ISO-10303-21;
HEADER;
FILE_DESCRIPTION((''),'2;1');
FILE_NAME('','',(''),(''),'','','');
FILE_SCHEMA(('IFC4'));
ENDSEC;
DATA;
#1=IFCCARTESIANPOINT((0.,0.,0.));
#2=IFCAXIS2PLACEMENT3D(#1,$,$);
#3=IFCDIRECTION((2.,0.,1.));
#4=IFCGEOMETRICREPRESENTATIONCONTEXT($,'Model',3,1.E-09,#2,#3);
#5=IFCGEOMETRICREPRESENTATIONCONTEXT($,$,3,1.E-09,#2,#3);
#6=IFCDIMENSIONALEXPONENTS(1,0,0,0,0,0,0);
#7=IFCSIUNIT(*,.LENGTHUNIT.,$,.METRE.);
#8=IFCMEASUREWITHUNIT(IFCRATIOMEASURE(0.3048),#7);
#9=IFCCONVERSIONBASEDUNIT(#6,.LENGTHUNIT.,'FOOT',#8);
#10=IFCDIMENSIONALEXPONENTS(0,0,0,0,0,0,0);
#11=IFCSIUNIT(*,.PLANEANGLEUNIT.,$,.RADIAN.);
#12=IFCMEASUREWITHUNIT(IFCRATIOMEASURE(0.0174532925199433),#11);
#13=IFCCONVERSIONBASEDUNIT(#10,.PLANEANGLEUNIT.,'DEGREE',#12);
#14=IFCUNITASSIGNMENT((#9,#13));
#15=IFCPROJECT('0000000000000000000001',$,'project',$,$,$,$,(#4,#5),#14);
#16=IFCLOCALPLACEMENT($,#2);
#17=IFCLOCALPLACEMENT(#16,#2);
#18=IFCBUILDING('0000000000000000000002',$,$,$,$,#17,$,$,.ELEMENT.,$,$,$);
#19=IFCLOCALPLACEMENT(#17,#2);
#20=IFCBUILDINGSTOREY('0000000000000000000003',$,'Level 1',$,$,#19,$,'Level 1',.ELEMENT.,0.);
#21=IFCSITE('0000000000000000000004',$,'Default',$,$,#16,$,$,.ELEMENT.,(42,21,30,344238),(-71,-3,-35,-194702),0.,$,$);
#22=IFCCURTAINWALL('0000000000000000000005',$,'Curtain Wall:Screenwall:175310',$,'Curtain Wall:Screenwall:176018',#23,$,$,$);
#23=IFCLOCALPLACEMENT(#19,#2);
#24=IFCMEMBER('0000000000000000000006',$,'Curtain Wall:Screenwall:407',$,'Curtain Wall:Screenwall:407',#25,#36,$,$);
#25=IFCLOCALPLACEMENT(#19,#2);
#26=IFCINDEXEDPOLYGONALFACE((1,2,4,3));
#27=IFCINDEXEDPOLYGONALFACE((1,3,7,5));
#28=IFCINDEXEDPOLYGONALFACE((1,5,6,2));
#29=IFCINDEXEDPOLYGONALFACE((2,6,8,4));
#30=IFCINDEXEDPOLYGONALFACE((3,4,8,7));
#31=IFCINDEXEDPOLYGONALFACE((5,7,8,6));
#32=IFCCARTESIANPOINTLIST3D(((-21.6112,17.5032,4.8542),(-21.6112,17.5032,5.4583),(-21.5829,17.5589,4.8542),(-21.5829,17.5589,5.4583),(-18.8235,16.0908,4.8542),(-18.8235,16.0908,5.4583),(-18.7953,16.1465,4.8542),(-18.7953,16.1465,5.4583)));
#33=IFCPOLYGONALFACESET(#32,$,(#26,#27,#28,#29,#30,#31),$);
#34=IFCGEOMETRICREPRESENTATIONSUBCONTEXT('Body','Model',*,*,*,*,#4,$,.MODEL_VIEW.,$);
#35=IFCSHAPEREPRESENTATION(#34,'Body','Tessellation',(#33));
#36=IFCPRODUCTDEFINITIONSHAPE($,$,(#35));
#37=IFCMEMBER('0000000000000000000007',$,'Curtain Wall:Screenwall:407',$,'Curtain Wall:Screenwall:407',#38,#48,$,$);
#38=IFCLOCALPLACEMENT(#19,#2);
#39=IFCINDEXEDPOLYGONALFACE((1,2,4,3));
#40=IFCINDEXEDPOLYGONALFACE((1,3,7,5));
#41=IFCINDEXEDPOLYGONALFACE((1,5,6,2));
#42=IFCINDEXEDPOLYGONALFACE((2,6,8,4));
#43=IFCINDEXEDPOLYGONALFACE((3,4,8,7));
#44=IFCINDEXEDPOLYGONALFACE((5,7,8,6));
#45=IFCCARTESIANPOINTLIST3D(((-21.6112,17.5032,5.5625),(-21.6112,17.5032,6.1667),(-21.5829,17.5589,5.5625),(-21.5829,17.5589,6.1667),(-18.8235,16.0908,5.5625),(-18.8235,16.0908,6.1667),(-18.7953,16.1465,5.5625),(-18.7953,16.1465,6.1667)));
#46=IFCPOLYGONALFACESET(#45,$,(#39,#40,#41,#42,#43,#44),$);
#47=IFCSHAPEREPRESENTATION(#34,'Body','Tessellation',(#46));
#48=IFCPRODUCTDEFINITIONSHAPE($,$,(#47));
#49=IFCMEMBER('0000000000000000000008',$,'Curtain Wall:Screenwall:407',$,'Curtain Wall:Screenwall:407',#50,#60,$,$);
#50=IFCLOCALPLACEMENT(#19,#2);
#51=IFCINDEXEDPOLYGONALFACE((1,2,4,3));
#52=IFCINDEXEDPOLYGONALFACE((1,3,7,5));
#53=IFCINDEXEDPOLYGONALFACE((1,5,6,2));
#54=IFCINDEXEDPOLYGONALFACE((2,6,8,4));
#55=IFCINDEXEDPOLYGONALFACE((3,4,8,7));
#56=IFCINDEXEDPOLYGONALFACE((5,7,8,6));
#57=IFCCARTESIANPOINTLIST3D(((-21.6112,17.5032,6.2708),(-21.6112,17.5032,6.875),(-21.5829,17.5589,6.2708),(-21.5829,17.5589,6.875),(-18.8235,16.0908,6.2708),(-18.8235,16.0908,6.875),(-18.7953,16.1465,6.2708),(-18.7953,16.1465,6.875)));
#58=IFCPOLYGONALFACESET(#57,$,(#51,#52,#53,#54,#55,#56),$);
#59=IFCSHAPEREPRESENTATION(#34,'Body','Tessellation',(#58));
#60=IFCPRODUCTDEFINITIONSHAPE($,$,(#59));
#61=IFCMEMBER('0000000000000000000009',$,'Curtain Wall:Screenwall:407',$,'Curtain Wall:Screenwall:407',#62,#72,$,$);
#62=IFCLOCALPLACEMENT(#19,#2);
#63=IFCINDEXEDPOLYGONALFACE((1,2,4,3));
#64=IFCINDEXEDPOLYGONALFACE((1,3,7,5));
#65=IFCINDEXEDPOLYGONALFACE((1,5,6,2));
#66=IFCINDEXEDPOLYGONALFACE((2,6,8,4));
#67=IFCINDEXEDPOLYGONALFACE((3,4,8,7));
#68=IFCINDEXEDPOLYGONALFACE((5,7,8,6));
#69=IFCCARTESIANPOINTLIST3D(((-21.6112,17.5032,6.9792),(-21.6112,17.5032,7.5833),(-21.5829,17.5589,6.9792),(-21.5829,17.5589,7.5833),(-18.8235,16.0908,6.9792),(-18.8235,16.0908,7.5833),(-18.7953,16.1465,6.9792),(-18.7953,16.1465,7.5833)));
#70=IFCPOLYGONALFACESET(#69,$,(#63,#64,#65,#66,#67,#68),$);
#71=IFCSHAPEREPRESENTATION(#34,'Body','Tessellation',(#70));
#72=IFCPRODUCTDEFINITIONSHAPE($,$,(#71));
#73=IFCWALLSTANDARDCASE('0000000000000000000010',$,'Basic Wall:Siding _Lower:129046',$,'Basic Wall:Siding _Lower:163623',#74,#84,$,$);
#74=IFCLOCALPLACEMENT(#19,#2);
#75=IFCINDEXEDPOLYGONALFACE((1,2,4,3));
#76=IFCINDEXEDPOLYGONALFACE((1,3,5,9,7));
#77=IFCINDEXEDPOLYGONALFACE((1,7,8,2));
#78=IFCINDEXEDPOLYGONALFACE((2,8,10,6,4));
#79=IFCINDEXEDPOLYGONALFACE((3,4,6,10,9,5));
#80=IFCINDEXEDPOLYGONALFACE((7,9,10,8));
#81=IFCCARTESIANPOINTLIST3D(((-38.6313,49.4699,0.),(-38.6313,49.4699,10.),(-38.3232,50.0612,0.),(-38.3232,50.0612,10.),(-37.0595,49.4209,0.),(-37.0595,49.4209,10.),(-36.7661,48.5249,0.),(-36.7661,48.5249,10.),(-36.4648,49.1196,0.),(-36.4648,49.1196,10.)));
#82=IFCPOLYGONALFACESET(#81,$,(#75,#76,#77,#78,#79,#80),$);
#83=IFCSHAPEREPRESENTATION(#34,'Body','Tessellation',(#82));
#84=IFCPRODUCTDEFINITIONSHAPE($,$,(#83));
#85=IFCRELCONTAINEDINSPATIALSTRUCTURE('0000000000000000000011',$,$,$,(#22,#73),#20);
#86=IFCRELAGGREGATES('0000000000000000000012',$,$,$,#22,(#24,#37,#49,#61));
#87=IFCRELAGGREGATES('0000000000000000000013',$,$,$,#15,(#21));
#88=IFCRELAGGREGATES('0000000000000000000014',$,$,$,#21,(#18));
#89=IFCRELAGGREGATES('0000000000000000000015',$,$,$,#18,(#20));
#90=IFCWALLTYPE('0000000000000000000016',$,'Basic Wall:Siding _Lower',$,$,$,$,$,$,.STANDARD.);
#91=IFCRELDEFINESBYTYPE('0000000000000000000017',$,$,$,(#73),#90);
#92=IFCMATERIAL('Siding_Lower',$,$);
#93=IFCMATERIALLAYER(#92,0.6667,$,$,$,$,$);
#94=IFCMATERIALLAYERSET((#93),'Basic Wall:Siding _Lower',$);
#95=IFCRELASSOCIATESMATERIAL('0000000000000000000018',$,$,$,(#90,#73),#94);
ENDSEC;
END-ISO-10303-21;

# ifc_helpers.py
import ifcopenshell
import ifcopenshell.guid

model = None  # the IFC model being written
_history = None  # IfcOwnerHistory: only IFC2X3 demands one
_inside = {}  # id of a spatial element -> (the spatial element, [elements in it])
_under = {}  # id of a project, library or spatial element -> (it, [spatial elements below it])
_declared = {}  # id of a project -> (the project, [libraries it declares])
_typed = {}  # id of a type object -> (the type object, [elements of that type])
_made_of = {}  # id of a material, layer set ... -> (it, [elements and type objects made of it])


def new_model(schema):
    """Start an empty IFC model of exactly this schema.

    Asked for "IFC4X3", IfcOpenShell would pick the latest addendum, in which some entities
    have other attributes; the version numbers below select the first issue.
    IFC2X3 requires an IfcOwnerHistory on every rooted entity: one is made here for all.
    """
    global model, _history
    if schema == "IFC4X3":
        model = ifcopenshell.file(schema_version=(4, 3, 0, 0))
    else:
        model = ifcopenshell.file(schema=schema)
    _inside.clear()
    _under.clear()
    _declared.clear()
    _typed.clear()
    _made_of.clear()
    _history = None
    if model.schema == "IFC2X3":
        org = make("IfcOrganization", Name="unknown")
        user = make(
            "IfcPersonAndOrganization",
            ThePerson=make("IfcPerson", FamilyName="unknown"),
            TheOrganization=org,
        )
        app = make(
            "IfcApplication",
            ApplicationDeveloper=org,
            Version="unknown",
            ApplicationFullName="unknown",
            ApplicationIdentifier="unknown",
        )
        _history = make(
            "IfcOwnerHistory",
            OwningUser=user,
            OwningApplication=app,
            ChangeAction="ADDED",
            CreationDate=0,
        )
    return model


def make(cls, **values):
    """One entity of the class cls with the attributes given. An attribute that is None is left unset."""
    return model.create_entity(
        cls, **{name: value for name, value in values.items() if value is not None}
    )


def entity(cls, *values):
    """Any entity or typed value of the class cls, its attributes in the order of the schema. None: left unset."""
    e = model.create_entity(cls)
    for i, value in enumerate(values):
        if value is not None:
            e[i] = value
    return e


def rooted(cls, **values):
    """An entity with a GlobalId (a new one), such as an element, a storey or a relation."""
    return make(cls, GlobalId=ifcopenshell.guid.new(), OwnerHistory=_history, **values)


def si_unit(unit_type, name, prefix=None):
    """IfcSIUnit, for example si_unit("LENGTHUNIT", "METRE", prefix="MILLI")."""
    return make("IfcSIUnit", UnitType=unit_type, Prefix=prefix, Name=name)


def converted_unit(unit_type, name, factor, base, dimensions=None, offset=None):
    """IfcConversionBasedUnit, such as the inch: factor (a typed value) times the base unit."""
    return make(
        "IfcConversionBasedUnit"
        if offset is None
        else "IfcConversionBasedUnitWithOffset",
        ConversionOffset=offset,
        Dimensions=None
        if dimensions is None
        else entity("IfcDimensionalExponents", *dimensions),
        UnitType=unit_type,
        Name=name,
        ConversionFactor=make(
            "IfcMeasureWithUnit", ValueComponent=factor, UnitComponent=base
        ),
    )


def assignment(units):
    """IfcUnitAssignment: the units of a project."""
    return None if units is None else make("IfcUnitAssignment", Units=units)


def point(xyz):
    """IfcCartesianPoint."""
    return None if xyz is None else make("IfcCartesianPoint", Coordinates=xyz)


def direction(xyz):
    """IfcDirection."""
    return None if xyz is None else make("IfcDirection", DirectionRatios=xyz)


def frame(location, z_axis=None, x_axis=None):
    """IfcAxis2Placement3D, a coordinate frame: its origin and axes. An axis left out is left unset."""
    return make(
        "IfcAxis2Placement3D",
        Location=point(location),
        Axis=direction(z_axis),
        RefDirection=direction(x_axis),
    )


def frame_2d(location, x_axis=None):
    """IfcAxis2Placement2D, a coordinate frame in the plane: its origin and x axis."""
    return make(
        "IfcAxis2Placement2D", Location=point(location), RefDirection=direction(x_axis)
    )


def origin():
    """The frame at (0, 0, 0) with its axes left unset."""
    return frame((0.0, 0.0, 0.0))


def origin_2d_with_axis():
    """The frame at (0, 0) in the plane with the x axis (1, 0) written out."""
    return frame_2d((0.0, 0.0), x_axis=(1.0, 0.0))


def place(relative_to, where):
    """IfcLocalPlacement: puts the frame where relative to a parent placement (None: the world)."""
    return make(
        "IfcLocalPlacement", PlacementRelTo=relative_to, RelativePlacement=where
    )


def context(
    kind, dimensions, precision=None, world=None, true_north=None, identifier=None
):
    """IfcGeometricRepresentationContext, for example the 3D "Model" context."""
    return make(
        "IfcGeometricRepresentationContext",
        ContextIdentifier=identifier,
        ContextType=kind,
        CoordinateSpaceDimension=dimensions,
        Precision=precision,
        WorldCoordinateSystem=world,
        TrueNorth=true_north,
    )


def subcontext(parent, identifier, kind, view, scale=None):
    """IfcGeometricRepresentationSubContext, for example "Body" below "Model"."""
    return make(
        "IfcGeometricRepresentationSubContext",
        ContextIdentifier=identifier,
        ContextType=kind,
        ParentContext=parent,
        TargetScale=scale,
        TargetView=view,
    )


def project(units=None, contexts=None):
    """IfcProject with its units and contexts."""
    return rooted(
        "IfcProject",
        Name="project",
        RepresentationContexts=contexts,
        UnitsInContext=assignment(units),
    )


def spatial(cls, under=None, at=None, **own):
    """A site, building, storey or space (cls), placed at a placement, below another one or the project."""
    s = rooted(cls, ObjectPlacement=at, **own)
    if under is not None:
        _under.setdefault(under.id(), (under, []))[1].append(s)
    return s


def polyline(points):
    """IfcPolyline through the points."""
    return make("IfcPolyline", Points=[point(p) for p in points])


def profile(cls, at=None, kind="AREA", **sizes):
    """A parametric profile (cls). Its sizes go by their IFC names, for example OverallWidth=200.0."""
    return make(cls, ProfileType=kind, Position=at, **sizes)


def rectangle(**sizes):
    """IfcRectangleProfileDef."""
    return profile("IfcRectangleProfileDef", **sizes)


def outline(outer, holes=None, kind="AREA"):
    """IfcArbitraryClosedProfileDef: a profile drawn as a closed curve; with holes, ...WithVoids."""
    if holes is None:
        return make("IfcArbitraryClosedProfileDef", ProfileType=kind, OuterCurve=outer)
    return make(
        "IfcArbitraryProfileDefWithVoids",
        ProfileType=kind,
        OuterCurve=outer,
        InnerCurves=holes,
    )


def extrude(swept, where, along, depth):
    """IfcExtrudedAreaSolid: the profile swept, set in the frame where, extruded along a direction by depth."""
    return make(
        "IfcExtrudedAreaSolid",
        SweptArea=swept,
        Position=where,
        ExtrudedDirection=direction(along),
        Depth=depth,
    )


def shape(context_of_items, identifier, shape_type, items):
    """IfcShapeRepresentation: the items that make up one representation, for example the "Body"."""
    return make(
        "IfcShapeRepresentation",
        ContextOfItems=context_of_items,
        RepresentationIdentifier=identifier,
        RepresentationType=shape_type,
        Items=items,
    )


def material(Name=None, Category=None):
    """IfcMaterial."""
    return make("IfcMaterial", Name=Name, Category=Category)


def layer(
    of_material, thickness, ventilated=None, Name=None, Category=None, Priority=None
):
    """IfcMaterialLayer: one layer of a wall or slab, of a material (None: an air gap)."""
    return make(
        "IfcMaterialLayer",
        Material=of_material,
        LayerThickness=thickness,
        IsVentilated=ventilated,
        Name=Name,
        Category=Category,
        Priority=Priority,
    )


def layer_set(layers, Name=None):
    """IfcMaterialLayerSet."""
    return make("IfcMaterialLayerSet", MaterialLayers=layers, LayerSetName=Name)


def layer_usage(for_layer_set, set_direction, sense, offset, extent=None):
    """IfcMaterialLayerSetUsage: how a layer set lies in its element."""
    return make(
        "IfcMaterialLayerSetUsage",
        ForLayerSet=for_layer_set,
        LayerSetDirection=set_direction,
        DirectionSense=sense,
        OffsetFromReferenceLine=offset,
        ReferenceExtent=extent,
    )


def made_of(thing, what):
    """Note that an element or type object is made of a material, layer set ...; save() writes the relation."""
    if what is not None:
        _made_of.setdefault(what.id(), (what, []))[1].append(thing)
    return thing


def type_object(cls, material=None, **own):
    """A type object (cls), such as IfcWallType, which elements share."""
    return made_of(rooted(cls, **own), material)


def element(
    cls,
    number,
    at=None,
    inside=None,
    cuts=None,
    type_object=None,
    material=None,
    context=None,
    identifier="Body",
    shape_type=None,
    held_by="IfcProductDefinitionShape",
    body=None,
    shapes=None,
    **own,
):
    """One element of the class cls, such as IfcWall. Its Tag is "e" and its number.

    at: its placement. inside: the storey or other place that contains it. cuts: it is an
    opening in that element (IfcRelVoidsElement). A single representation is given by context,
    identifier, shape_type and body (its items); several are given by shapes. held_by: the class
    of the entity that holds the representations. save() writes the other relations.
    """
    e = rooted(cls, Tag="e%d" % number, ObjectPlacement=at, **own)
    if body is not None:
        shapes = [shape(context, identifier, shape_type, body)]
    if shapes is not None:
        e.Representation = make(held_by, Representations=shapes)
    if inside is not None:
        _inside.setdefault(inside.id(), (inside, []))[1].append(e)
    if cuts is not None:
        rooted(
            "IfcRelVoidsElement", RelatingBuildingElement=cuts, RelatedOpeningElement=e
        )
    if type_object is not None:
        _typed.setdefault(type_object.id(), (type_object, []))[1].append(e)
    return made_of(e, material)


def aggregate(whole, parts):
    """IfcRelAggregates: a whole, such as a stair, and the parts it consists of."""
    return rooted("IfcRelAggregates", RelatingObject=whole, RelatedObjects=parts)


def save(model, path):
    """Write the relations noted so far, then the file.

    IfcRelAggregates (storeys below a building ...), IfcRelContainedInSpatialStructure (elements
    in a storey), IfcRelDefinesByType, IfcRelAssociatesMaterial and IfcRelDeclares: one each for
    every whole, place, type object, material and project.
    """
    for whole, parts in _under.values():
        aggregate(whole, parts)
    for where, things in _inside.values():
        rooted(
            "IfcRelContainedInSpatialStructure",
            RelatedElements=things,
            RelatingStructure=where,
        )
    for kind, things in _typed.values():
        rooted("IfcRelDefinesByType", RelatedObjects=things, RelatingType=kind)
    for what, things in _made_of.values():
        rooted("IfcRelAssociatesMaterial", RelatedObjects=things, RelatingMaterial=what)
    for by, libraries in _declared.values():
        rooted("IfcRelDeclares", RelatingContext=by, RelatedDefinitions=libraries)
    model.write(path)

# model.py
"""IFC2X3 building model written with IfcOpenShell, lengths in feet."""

from ifc_helpers import new_model, entity, si_unit, converted_unit, direction, frame, origin, origin_2d_with_axis, place, context, subcontext, project, spatial, polyline, rectangle, outline, extrude, material, layer, layer_set, layer_usage, type_object, element, aggregate, save


model = new_model("IFC2X3")

# Units and contexts
model_context = context("Model", 3, precision=1e-09, world=origin(), true_north=direction((2.0, 0.0, 1.0)))
context_of_model = context(None, 3, precision=1e-09, world=origin(), true_north=direction((2.0, 0.0, 1.0)))
body_context = subcontext(model_context, "Body", "Model", "MODEL_VIEW")
ifc_project = project(units=[converted_unit("LENGTHUNIT", "FOOT", entity("IfcRatioMeasure", 0.3048), si_unit("LENGTHUNIT", "METRE"), dimensions=[1, 0, 0, 0, 0, 0, 0]), converted_unit("PLANEANGLEUNIT", "DEGREE", entity("IfcRatioMeasure", 0.0174532925199433), si_unit("PLANEANGLEUNIT", "RADIAN"), dimensions=[0, 0, 0, 0, 0, 0, 0])], contexts=[model_context, context_of_model])

# Site, building, storey
site_placement = place(None, origin())
site = spatial("IfcSite", under=ifc_project, at=site_placement, Name="Default", CompositionType="ELEMENT", RefLatitude=(42, 21, 30, 344238), RefLongitude=(-71, -3, -35, -194702), RefElevation=0.0)
building_placement = place(site_placement, origin())
building = spatial("IfcBuilding", under=site, at=building_placement, CompositionType="ELEMENT")
storey_placement = place(building_placement, origin())
storey = spatial("IfcBuildingStorey", under=building, at=storey_placement, Name="Level 1", LongName="Level 1", CompositionType="ELEMENT", Elevation=0.0)

# Curtain wall, members
curtain_wall_1_placement = place(storey_placement, origin())
curtain_wall_1 = element("IfcCurtainWall", 1, at=curtain_wall_1_placement, inside=storey, Name="Curtain Wall:Screenwall:175310", ObjectType="Curtain Wall:Screenwall:176018")
member_1_placement = place(curtain_wall_1_placement, frame((-21.6112, 16.0908, 4.8542)))
member_1 = element("IfcMember", 2, at=member_1_placement, Name="Curtain Wall:Screenwall:407", ObjectType="Curtain Wall:Screenwall:407", context=body_context, shape_type="SweptSolid", body=[
    extrude(rectangle(XDim=3.1251, YDim=0.0625, at=origin_2d_with_axis()), frame((1.408, 0.7341, 0.0), z_axis=(0.0, 0.0, 1.0), x_axis=(0.892034, -0.451968, 0.0)), (0.0, 0.0, 1.0), 0.6042),
])
member_2_placement = place(curtain_wall_1_placement, frame((-21.6112, 16.0908, 5.5625)))
member_2 = element("IfcMember", 3, at=member_2_placement, Name="Curtain Wall:Screenwall:407", ObjectType="Curtain Wall:Screenwall:407", context=body_context, shape_type="SweptSolid", body=[
    extrude(rectangle(XDim=3.1251, YDim=0.0625, at=origin_2d_with_axis()), frame((1.408, 0.7341, 0.0), z_axis=(0.0, 0.0, 1.0), x_axis=(0.892034, -0.451968, 0.0)), (0.0, 0.0, 1.0), 0.6042),
])
member_3_placement = place(curtain_wall_1_placement, frame((-21.6112, 16.0908, 6.2708)))
member_3 = element("IfcMember", 4, at=member_3_placement, Name="Curtain Wall:Screenwall:407", ObjectType="Curtain Wall:Screenwall:407", context=body_context, shape_type="SweptSolid", body=[
    extrude(rectangle(XDim=3.1251, YDim=0.0625, at=origin_2d_with_axis()), frame((1.408, 0.7341, 0.0), z_axis=(0.0, 0.0, 1.0), x_axis=(0.892034, -0.451968, 0.0)), (0.0, 0.0, 1.0), 0.6042),
])
member_4_placement = place(curtain_wall_1_placement, frame((-21.6112, 16.0908, 6.9792)))
member_4 = element("IfcMember", 5, at=member_4_placement, Name="Curtain Wall:Screenwall:407", ObjectType="Curtain Wall:Screenwall:407", context=body_context, shape_type="SweptSolid", body=[
    extrude(rectangle(XDim=3.1251, YDim=0.0625, at=origin_2d_with_axis()), frame((1.408, 0.7341, 0.0), z_axis=(0.0, 0.0, 1.0), x_axis=(0.892034, -0.451968, 0.0)), (0.0, 0.0, 1.0), 0.6042),
])
aggregate(curtain_wall_1, [member_1, member_2, member_3, member_4])

# Wall
ifc_material_1 = material(Name="Siding_Lower")
ifc_layer = layer(ifc_material_1, 0.6667)
ifc_layer_set = layer_set([ifc_layer], Name="Basic Wall:Siding _Lower")
ifc_layer_usage_1 = layer_usage(ifc_layer_set, "AXIS2", "NEGATIVE", 0.3333)
wall_type = type_object("IfcWallType", Name="Basic Wall:Siding _Lower", PredefinedType="STANDARD", material=ifc_layer_set)
wall_1_placement = place(storey_placement, frame((-38.4807, 49.7673, 0.0), z_axis=(0.0, 0.0, 1.0), x_axis=(0.892035, -0.451966, 0.0)))
element("IfcWallStandardCase", 6, at=wall_1_placement, inside=storey, type_object=wall_type, material=ifc_layer_usage_1, Name="Basic Wall:Siding _Lower:129046", ObjectType="Basic Wall:Siding _Lower:163623", context=body_context, shape_type="SweptSolid", body=[
    extrude(outline(polyline([(2.0909, -0.3333), (2.0909, 0.3333), (1.4243, 0.3333), (0.0077, 0.3333), (0.0, -0.3333), (2.0909, -0.3333)])), origin(), (0.0, 0.0, 1.0), 10.0),
])

save(model, "model.ifc")
